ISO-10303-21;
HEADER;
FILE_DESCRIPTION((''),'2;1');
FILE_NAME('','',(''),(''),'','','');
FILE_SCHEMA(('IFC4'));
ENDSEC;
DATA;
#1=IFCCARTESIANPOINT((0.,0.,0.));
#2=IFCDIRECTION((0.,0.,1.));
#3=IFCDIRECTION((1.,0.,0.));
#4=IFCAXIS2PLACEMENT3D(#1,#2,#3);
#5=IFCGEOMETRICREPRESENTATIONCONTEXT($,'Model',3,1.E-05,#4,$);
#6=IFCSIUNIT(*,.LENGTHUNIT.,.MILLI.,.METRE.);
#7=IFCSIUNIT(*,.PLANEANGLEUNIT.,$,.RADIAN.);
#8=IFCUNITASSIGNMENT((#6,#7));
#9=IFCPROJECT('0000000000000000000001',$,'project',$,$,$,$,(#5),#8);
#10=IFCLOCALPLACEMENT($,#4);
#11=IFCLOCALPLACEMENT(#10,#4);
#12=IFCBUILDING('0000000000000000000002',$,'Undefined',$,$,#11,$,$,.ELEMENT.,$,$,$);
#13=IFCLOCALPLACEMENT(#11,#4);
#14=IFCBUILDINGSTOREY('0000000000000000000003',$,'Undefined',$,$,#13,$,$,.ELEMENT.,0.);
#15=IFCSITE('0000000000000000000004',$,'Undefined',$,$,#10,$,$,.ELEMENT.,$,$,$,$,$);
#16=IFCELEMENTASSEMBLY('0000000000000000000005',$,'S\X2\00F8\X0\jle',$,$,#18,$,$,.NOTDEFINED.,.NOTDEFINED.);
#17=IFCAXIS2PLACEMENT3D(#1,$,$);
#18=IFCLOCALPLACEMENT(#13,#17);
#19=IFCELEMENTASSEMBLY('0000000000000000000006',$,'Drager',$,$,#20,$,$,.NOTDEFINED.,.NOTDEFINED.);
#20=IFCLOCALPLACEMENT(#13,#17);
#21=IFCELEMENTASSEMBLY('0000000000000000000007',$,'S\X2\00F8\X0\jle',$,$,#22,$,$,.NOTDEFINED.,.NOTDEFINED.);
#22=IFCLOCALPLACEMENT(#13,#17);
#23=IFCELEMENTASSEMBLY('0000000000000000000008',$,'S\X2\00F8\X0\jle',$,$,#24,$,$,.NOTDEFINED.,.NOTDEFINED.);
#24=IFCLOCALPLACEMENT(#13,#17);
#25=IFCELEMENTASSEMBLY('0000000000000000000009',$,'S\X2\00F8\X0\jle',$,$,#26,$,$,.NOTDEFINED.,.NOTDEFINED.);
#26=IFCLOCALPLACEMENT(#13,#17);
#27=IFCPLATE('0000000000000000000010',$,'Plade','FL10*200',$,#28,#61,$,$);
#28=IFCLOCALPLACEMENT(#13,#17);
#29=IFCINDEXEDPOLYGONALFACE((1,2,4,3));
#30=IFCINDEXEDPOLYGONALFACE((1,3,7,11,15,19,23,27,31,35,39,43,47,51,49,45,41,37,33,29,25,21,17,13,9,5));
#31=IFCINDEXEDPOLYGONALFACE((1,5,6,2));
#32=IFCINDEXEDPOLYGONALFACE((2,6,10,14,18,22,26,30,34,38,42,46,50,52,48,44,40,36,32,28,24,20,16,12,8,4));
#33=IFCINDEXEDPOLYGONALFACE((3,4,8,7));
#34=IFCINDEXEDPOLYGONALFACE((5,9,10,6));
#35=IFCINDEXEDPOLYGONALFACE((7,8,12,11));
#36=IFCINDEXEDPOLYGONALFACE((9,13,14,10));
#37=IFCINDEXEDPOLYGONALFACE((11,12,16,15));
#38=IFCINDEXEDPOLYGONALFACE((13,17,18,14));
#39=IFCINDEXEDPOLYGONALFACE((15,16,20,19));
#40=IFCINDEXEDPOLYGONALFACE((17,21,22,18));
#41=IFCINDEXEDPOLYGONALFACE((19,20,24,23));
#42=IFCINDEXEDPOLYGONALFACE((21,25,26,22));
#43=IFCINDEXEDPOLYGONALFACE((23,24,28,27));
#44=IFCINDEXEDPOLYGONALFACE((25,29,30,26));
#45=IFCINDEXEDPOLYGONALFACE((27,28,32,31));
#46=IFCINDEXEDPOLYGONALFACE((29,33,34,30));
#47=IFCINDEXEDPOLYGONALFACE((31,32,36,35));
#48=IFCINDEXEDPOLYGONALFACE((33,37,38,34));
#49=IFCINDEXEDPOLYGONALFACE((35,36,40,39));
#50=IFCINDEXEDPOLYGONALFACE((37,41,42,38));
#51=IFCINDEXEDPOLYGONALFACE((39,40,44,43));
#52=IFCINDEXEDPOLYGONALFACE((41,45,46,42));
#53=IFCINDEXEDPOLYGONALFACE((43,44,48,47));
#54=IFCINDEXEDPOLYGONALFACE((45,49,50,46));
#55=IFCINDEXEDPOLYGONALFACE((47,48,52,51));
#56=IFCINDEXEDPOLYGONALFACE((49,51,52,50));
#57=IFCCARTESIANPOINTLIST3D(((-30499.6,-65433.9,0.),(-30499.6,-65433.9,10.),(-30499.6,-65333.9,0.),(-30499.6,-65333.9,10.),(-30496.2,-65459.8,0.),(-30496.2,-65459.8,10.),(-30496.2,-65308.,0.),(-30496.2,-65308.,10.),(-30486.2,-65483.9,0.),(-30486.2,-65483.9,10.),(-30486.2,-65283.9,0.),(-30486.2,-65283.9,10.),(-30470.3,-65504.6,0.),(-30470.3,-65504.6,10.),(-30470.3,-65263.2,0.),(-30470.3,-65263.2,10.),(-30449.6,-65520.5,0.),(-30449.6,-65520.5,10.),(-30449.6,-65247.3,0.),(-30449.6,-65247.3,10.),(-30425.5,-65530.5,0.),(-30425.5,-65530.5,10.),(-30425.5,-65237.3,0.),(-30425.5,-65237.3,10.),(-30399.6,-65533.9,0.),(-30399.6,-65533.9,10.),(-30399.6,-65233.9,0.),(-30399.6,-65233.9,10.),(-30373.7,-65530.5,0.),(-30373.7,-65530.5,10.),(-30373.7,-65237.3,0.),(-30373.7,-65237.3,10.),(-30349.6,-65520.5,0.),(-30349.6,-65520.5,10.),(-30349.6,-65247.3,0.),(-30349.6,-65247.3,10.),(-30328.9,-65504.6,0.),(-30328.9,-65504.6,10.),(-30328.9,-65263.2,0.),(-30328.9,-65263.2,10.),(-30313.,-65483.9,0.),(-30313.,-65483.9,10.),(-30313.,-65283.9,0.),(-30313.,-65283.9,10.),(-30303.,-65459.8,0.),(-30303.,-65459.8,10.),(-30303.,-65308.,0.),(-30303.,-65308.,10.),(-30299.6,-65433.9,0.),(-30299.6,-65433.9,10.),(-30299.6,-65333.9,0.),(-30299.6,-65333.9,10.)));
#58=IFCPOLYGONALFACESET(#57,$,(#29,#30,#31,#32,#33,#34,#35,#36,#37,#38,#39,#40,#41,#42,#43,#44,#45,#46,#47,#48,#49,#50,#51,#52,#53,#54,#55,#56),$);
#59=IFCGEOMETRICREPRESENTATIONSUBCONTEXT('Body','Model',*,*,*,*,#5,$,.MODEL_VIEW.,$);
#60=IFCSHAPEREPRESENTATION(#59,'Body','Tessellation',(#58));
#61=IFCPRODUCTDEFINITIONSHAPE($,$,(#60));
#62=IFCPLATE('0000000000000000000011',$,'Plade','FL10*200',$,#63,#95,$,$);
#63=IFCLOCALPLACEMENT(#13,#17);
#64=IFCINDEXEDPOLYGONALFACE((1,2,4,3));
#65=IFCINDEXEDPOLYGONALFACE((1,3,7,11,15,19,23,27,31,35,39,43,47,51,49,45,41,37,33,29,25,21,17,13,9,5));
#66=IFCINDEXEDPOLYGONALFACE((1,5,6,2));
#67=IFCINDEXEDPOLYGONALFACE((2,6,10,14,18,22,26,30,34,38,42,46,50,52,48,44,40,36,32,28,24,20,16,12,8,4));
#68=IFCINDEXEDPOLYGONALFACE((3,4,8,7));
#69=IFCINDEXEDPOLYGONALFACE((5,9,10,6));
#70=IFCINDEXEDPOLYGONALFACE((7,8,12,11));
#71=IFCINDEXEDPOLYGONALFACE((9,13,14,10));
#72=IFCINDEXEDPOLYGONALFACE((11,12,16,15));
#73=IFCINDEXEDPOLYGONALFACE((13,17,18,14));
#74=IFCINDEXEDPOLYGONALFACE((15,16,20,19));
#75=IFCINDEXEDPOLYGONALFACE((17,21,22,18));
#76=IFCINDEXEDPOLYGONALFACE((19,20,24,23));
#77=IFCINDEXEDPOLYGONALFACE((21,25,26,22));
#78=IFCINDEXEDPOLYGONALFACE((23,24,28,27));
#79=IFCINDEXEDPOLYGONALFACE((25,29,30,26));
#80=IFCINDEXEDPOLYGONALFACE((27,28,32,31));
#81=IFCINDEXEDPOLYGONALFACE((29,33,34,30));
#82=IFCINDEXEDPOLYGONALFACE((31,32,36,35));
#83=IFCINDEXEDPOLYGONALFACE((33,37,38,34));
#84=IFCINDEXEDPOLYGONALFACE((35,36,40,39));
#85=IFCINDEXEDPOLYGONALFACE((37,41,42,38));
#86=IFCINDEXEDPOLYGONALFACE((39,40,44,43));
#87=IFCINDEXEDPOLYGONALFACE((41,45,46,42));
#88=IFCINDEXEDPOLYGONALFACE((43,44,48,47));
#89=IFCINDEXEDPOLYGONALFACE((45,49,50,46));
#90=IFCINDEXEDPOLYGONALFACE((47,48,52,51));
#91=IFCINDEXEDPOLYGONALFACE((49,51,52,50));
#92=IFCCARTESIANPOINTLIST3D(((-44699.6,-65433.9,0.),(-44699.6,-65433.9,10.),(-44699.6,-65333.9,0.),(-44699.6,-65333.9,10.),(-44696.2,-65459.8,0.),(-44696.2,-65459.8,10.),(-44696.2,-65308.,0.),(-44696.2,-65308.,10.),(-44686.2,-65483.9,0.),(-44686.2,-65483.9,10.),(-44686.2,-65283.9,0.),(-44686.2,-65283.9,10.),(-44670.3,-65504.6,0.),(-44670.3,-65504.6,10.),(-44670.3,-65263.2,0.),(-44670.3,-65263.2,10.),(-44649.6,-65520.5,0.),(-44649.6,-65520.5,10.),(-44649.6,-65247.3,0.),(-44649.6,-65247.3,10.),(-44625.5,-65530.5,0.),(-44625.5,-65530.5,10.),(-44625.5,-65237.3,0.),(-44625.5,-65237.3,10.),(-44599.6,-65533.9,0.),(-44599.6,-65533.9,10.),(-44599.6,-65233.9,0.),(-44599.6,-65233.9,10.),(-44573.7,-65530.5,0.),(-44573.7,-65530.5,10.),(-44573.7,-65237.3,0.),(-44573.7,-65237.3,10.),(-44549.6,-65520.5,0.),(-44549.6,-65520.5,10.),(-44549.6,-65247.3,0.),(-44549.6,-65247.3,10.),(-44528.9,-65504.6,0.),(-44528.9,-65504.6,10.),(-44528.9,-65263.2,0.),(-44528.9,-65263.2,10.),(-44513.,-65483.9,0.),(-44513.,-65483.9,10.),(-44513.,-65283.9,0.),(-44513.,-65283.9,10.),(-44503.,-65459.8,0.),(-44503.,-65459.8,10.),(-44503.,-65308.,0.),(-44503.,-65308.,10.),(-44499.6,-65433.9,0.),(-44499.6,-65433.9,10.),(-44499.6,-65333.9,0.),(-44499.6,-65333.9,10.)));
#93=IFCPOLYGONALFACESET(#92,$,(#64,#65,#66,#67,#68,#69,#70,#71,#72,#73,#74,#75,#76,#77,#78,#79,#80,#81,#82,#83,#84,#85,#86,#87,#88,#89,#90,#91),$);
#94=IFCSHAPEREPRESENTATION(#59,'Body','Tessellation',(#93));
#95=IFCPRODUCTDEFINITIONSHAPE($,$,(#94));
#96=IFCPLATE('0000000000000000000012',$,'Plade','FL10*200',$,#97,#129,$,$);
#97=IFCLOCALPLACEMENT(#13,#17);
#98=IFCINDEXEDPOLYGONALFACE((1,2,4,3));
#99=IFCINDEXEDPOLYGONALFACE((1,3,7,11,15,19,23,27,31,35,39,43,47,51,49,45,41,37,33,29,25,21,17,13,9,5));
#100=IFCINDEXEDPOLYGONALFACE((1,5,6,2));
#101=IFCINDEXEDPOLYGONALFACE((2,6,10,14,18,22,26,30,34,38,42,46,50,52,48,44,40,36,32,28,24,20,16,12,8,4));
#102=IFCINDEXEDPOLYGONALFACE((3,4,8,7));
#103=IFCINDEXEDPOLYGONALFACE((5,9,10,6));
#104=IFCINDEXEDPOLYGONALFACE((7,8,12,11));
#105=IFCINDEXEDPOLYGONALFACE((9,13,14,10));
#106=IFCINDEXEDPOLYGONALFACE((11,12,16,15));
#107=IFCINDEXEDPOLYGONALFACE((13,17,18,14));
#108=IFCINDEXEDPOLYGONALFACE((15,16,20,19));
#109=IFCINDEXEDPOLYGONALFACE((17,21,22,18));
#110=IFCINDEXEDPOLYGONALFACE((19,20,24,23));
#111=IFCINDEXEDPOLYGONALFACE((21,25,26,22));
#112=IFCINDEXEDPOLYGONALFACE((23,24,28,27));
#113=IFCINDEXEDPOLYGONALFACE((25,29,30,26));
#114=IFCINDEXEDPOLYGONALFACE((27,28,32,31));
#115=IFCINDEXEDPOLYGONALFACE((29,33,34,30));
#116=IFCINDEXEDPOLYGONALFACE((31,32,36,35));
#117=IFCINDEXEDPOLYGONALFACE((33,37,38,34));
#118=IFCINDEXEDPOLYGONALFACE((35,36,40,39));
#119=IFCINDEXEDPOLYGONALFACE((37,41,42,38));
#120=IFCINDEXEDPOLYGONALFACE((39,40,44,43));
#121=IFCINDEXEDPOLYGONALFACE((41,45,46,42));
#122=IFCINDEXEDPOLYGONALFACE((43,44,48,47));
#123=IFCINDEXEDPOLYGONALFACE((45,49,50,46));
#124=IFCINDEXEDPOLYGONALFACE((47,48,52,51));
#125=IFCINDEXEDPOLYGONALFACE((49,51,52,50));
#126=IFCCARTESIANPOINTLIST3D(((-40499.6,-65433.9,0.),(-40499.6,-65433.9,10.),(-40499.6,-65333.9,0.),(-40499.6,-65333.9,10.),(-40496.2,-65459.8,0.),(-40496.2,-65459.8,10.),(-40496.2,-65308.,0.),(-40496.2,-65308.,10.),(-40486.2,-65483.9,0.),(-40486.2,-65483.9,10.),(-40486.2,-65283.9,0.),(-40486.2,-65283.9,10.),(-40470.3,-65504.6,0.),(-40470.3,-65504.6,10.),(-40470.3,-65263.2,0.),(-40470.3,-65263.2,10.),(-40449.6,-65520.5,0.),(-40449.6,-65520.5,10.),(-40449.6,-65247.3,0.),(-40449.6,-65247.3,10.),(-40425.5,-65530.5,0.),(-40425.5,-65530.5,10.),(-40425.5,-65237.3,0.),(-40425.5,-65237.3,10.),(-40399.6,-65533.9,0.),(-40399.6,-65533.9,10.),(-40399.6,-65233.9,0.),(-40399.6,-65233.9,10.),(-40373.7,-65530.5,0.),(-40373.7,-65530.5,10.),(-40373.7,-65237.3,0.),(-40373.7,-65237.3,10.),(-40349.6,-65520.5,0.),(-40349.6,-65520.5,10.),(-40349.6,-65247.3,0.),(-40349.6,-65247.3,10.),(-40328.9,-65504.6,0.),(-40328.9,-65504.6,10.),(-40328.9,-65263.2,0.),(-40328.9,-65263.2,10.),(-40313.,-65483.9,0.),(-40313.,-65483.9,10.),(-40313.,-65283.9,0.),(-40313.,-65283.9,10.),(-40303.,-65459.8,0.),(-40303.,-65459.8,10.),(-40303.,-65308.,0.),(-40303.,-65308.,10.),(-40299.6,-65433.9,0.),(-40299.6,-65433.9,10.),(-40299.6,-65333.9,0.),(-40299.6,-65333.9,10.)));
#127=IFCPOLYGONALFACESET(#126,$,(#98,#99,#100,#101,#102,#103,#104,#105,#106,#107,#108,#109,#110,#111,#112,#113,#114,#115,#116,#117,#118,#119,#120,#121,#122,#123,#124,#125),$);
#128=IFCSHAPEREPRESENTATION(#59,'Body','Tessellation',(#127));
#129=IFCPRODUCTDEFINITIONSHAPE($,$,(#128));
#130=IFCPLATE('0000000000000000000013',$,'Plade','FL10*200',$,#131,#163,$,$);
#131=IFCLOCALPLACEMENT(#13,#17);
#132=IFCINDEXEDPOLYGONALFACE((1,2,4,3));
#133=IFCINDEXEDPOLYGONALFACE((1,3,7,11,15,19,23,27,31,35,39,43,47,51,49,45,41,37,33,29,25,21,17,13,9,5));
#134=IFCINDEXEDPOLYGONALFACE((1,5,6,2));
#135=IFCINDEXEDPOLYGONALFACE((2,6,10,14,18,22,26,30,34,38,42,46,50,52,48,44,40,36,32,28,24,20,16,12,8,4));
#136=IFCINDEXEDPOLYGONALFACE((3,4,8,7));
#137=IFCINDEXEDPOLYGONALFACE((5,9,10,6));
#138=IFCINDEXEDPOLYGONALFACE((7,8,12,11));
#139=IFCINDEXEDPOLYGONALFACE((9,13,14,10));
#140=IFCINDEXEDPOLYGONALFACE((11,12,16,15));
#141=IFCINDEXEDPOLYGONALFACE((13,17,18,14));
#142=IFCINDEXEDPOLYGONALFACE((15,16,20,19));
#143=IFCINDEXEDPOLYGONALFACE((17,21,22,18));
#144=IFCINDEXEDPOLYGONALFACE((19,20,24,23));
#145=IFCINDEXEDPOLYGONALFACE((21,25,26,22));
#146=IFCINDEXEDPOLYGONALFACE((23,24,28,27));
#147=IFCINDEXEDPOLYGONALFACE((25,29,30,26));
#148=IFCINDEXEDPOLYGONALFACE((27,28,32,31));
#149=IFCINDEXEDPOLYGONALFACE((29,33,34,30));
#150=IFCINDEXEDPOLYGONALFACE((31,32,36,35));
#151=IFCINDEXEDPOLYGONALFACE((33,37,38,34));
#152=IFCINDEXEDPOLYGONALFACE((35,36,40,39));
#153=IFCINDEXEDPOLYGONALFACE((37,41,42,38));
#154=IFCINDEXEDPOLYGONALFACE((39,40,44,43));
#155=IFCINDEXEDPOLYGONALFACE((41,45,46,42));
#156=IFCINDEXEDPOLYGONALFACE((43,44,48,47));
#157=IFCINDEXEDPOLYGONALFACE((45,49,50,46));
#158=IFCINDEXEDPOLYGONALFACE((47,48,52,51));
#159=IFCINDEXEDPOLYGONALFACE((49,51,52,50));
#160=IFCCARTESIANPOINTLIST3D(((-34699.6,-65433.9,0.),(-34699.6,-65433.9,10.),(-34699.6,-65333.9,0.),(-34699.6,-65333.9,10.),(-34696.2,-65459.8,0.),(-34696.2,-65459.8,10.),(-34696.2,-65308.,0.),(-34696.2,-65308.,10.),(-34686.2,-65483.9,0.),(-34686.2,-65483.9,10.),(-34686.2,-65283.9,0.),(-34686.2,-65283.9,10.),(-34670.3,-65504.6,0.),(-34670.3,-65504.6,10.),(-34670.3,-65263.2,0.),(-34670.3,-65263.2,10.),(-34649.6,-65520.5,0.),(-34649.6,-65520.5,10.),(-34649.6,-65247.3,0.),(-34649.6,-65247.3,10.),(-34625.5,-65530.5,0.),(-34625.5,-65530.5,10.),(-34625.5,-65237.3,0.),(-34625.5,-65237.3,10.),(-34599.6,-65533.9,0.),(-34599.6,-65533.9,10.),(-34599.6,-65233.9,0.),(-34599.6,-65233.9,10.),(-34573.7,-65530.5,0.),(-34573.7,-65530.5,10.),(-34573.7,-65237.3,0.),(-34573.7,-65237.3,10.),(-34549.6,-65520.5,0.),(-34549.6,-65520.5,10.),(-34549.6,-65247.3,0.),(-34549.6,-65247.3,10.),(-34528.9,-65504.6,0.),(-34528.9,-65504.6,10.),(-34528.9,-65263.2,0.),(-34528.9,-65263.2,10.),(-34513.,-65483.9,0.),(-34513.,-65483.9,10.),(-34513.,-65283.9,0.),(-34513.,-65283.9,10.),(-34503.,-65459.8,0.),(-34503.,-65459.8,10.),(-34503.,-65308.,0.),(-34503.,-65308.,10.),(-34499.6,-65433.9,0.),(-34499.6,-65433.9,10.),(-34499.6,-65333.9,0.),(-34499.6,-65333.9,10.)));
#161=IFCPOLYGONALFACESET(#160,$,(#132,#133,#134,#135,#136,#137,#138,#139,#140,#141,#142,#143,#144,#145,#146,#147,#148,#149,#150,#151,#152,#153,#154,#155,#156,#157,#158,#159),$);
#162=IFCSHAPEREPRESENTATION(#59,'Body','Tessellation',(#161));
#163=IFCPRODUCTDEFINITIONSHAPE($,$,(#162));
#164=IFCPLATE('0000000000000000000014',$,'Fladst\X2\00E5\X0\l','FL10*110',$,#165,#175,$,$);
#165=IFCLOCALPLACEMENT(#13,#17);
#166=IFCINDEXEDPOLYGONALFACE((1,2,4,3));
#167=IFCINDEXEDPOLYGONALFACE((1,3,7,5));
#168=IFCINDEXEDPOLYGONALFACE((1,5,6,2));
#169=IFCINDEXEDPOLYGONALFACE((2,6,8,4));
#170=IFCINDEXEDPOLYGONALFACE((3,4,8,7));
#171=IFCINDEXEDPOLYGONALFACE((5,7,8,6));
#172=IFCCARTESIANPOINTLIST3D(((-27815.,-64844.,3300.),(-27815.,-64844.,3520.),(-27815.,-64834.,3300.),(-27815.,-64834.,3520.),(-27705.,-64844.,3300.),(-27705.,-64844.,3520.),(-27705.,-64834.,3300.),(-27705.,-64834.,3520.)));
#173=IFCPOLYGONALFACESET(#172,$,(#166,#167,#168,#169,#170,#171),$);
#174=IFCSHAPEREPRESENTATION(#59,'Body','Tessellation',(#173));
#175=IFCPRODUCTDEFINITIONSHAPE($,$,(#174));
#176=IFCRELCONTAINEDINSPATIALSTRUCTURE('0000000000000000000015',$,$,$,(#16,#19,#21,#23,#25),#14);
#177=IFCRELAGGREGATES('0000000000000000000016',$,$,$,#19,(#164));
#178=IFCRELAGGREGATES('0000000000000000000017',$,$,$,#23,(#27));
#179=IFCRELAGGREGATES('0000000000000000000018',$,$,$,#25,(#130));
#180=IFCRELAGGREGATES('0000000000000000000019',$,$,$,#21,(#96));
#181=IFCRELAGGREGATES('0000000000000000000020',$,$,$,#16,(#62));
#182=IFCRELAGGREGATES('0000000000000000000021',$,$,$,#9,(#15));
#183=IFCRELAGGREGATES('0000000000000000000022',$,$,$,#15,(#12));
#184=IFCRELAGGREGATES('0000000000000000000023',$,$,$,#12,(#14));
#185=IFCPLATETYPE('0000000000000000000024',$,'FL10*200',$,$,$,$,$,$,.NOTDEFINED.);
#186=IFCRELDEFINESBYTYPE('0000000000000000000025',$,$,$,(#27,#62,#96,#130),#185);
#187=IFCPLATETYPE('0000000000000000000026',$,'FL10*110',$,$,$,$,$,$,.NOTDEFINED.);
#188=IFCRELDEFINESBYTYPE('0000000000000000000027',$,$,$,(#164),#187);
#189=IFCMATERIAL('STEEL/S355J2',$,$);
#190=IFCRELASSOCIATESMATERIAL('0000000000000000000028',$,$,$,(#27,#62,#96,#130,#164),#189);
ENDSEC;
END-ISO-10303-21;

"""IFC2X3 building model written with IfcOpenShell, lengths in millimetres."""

from ifc_helpers import new_model, si_unit, frame, frame_2d, origin_with_axes, place, context, subcontext, project, spatial, polyline, circle_curve, parameter, trimmed, segment, composite_curve, outline, extrude, material, type_object, element, aggregate, save


model = new_model("IFC2X3")

# Units and contexts
model_context = context("Model", 3, precision=1e-05, world=origin_with_axes())
body_context = subcontext(model_context, "Body", "Model", "MODEL_VIEW")
ifc_project = project(units=[si_unit("LENGTHUNIT", "METRE", prefix="MILLI"), si_unit("PLANEANGLEUNIT", "RADIAN")], contexts=[model_context])

# Site, building, storey
site_placement = place(None, origin_with_axes())
site = spatial("IfcSite", under=ifc_project, at=site_placement, Name="Undefined", CompositionType="ELEMENT")
building_placement = place(site_placement, origin_with_axes())
building = spatial("IfcBuilding", under=site, at=building_placement, Name="Undefined", CompositionType="ELEMENT")
storey_placement = place(building_placement, origin_with_axes())
storey = spatial("IfcBuildingStorey", under=building, at=storey_placement, Name="Undefined", CompositionType="ELEMENT", Elevation=0.0)

# Element assembly
assembly_1_placement = place(storey_placement, origin_with_axes())
assembly_1 = element("IfcElementAssembly", 1, at=assembly_1_placement, inside=storey, Name="Søjle", AssemblyPlace="NOTDEFINED", PredefinedType="NOTDEFINED")
ifc_material_1 = material(Name="STEEL/S355J2")

# Element assembly
assembly_2_placement = place(storey_placement, origin_with_axes())
assembly_2 = element("IfcElementAssembly", 2, at=assembly_2_placement, inside=storey, Name="Drager", AssemblyPlace="NOTDEFINED", PredefinedType="NOTDEFINED")

# Element assemblies
assembly_3_placement = place(storey_placement, origin_with_axes())
assembly_3 = element("IfcElementAssembly", 3, at=assembly_3_placement, inside=storey, Name="Søjle", AssemblyPlace="NOTDEFINED", PredefinedType="NOTDEFINED")
assembly_4_placement = place(storey_placement, origin_with_axes())
assembly_4 = element("IfcElementAssembly", 4, at=assembly_4_placement, inside=storey, Name="Søjle", AssemblyPlace="NOTDEFINED", PredefinedType="NOTDEFINED")
assembly_5_placement = place(storey_placement, origin_with_axes())
assembly_5 = element("IfcElementAssembly", 5, at=assembly_5_placement, inside=storey, Name="Søjle", AssemblyPlace="NOTDEFINED", PredefinedType="NOTDEFINED")

# Plates
plate_type_1 = type_object("IfcPlateType", Name="FL10*200", PredefinedType="NOTDEFINED")
plate_1_placement = place(assembly_4_placement, frame((-30499.6, -65233.9, 5.0), z_axis=(0.0, 0.0, -1.0), x_axis=(1.0, 0.0, 0.0)))
plate_1 = element("IfcPlate", 6, at=plate_1_placement, type_object=plate_type_1, material=ifc_material_1, Name="Plade", Description="FL10*200", context=body_context, shape_type="SweptSolid", body=[
    extrude(outline(composite_curve([segment(trimmed(circle_curve(frame_2d((100.0, 100.0), x_axis=(-1.0, 0.0)), 100.0), [parameter(0.0)], [parameter(1.570796)], True, "PARAMETER"), True, "CONTINUOUS"), segment(polyline([(100.0, 0.0), (100.0, 0.0)]), True, "CONTINUOUS"), segment(trimmed(circle_curve(frame_2d((100.0, 100.0), x_axis=(0.0, -1.0)), 100.0), [parameter(0.0)], [parameter(1.570796)], True, "PARAMETER"), True, "CONTINUOUS"), segment(polyline([(200.0, 100.0), (200.0, 200.0)]), True, "CONTINUOUS"), segment(trimmed(circle_curve(frame_2d((100.0, 200.0), x_axis=(1.0, 0.0)), 100.0), [parameter(0.0)], [parameter(1.570796)], True, "PARAMETER"), True, "CONTINUOUS"), segment(polyline([(100.0, 300.0), (100.0, 300.0)]), True, "CONTINUOUS"), segment(trimmed(circle_curve(frame_2d((100.0, 200.0), x_axis=(0.0, 1.0)), 100.0), [parameter(0.0)], [parameter(1.570796)], True, "PARAMETER"), True, "CONTINUOUS"), segment(polyline([(0.0, 200.0), (0.0, 100.0)]), True, "CONTINUOUS")], self_intersect=True)), frame((0.0, 0.0, -5.0), z_axis=(0.0, 0.0, 1.0), x_axis=(1.0, 0.0, 0.0)), (0.0, 0.0, 1.0), 10.0),
])
plate_2_placement = place(assembly_1_placement, frame((-44699.6, -65233.9, 5.0), z_axis=(0.0, 0.0, -1.0), x_axis=(1.0, 0.0, 0.0)))
plate_2 = element("IfcPlate", 7, at=plate_2_placement, type_object=plate_type_1, material=ifc_material_1, Name="Plade", Description="FL10*200", context=body_context, shape_type="SweptSolid", body=[
    extrude(outline(composite_curve([segment(trimmed(circle_curve(frame_2d((100.0, 100.0), x_axis=(-1.0, 0.0)), 100.0), [parameter(0.0)], [parameter(1.570796)], True, "PARAMETER"), True, "CONTINUOUS"), segment(polyline([(100.0, 0.0), (100.0, 0.0)]), True, "CONTINUOUS"), segment(trimmed(circle_curve(frame_2d((100.0, 100.0), x_axis=(0.0, -1.0)), 100.0), [parameter(0.0)], [parameter(1.570796)], True, "PARAMETER"), True, "CONTINUOUS"), segment(polyline([(200.0, 100.0), (200.0, 200.0)]), True, "CONTINUOUS"), segment(trimmed(circle_curve(frame_2d((100.0, 200.0), x_axis=(1.0, 0.0)), 100.0), [parameter(0.0)], [parameter(1.570796)], True, "PARAMETER"), True, "CONTINUOUS"), segment(polyline([(100.0, 300.0), (100.0, 300.0)]), True, "CONTINUOUS"), segment(trimmed(circle_curve(frame_2d((100.0, 200.0), x_axis=(0.0, 1.0)), 100.0), [parameter(0.0)], [parameter(1.570796)], True, "PARAMETER"), True, "CONTINUOUS"), segment(polyline([(0.0, 200.0), (0.0, 100.0)]), True, "CONTINUOUS")], self_intersect=True)), frame((0.0, 0.0, -5.0), z_axis=(0.0, 0.0, 1.0), x_axis=(1.0, 0.0, 0.0)), (0.0, 0.0, 1.0), 10.0),
])
plate_3_placement = place(assembly_3_placement, frame((-40499.6, -65233.9, 5.0), z_axis=(0.0, 0.0, -1.0), x_axis=(1.0, 0.0, 0.0)))
plate_3 = element("IfcPlate", 8, at=plate_3_placement, type_object=plate_type_1, material=ifc_material_1, Name="Plade", Description="FL10*200", context=body_context, shape_type="SweptSolid", body=[
    extrude(outline(composite_curve([segment(trimmed(circle_curve(frame_2d((100.0, 100.0), x_axis=(-1.0, 0.0)), 100.0), [parameter(0.0)], [parameter(1.570796)], True, "PARAMETER"), True, "CONTINUOUS"), segment(polyline([(100.0, 0.0), (100.0, 0.0)]), True, "CONTINUOUS"), segment(trimmed(circle_curve(frame_2d((100.0, 100.0), x_axis=(0.0, -1.0)), 100.0), [parameter(0.0)], [parameter(1.570796)], True, "PARAMETER"), True, "CONTINUOUS"), segment(polyline([(200.0, 100.0), (200.0, 200.0)]), True, "CONTINUOUS"), segment(trimmed(circle_curve(frame_2d((100.0, 200.0), x_axis=(1.0, 0.0)), 100.0), [parameter(0.0)], [parameter(1.570796)], True, "PARAMETER"), True, "CONTINUOUS"), segment(polyline([(100.0, 300.0), (100.0, 300.0)]), True, "CONTINUOUS"), segment(trimmed(circle_curve(frame_2d((100.0, 200.0), x_axis=(0.0, 1.0)), 100.0), [parameter(0.0)], [parameter(1.570796)], True, "PARAMETER"), True, "CONTINUOUS"), segment(polyline([(0.0, 200.0), (0.0, 100.0)]), True, "CONTINUOUS")], self_intersect=True)), frame((0.0, 0.0, -5.0), z_axis=(0.0, 0.0, 1.0), x_axis=(1.0, 0.0, 0.0)), (0.0, 0.0, 1.0), 10.0),
])
plate_4_placement = place(assembly_5_placement, frame((-34699.6, -65233.9, 5.0), z_axis=(0.0, 0.0, -1.0), x_axis=(1.0, 0.0, 0.0)))
plate_4 = element("IfcPlate", 9, at=plate_4_placement, type_object=plate_type_1, material=ifc_material_1, Name="Plade", Description="FL10*200", context=body_context, shape_type="SweptSolid", body=[
    extrude(outline(composite_curve([segment(trimmed(circle_curve(frame_2d((100.0, 100.0), x_axis=(-1.0, 0.0)), 100.0), [parameter(0.0)], [parameter(1.570796)], True, "PARAMETER"), True, "CONTINUOUS"), segment(polyline([(100.0, 0.0), (100.0, 0.0)]), True, "CONTINUOUS"), segment(trimmed(circle_curve(frame_2d((100.0, 100.0), x_axis=(0.0, -1.0)), 100.0), [parameter(0.0)], [parameter(1.570796)], True, "PARAMETER"), True, "CONTINUOUS"), segment(polyline([(200.0, 100.0), (200.0, 200.0)]), True, "CONTINUOUS"), segment(trimmed(circle_curve(frame_2d((100.0, 200.0), x_axis=(1.0, 0.0)), 100.0), [parameter(0.0)], [parameter(1.570796)], True, "PARAMETER"), True, "CONTINUOUS"), segment(polyline([(100.0, 300.0), (100.0, 300.0)]), True, "CONTINUOUS"), segment(trimmed(circle_curve(frame_2d((100.0, 200.0), x_axis=(0.0, 1.0)), 100.0), [parameter(0.0)], [parameter(1.570796)], True, "PARAMETER"), True, "CONTINUOUS"), segment(polyline([(0.0, 200.0), (0.0, 100.0)]), True, "CONTINUOUS")], self_intersect=True)), frame((0.0, 0.0, -5.0), z_axis=(0.0, 0.0, 1.0), x_axis=(1.0, 0.0, 0.0)), (0.0, 0.0, 1.0), 10.0),
])
plate_type_2 = type_object("IfcPlateType", Name="FL10*110", PredefinedType="NOTDEFINED")
plate_5_placement = place(assembly_2_placement, frame((-27760.0, -64839.0, 3300.0), z_axis=(0.0, -1.0, 0.0), x_axis=(0.0, 0.0, 1.0)))
plate_5 = element("IfcPlate", 10, at=plate_5_placement, type_object=plate_type_2, material=ifc_material_1, Name="Fladstål", Description="FL10*110", context=body_context, shape_type="SweptSolid", body=[
    extrude(outline(polyline([(0.0, -55.0), (0.0, 55.0), (220.0, 55.0), (220.0, -55.0), (0.0, -55.0)])), frame((0.0, 0.0, -5.0), z_axis=(0.0, 0.0, 1.0), x_axis=(1.0, 0.0, 0.0)), (0.0, 0.0, 1.0), 10.0),
])

aggregate(assembly_2, [plate_5])

aggregate(assembly_4, [plate_1])
aggregate(assembly_5, [plate_4])
aggregate(assembly_3, [plate_3])
aggregate(assembly_1, [plate_2])

save(model, "model.ifc")
